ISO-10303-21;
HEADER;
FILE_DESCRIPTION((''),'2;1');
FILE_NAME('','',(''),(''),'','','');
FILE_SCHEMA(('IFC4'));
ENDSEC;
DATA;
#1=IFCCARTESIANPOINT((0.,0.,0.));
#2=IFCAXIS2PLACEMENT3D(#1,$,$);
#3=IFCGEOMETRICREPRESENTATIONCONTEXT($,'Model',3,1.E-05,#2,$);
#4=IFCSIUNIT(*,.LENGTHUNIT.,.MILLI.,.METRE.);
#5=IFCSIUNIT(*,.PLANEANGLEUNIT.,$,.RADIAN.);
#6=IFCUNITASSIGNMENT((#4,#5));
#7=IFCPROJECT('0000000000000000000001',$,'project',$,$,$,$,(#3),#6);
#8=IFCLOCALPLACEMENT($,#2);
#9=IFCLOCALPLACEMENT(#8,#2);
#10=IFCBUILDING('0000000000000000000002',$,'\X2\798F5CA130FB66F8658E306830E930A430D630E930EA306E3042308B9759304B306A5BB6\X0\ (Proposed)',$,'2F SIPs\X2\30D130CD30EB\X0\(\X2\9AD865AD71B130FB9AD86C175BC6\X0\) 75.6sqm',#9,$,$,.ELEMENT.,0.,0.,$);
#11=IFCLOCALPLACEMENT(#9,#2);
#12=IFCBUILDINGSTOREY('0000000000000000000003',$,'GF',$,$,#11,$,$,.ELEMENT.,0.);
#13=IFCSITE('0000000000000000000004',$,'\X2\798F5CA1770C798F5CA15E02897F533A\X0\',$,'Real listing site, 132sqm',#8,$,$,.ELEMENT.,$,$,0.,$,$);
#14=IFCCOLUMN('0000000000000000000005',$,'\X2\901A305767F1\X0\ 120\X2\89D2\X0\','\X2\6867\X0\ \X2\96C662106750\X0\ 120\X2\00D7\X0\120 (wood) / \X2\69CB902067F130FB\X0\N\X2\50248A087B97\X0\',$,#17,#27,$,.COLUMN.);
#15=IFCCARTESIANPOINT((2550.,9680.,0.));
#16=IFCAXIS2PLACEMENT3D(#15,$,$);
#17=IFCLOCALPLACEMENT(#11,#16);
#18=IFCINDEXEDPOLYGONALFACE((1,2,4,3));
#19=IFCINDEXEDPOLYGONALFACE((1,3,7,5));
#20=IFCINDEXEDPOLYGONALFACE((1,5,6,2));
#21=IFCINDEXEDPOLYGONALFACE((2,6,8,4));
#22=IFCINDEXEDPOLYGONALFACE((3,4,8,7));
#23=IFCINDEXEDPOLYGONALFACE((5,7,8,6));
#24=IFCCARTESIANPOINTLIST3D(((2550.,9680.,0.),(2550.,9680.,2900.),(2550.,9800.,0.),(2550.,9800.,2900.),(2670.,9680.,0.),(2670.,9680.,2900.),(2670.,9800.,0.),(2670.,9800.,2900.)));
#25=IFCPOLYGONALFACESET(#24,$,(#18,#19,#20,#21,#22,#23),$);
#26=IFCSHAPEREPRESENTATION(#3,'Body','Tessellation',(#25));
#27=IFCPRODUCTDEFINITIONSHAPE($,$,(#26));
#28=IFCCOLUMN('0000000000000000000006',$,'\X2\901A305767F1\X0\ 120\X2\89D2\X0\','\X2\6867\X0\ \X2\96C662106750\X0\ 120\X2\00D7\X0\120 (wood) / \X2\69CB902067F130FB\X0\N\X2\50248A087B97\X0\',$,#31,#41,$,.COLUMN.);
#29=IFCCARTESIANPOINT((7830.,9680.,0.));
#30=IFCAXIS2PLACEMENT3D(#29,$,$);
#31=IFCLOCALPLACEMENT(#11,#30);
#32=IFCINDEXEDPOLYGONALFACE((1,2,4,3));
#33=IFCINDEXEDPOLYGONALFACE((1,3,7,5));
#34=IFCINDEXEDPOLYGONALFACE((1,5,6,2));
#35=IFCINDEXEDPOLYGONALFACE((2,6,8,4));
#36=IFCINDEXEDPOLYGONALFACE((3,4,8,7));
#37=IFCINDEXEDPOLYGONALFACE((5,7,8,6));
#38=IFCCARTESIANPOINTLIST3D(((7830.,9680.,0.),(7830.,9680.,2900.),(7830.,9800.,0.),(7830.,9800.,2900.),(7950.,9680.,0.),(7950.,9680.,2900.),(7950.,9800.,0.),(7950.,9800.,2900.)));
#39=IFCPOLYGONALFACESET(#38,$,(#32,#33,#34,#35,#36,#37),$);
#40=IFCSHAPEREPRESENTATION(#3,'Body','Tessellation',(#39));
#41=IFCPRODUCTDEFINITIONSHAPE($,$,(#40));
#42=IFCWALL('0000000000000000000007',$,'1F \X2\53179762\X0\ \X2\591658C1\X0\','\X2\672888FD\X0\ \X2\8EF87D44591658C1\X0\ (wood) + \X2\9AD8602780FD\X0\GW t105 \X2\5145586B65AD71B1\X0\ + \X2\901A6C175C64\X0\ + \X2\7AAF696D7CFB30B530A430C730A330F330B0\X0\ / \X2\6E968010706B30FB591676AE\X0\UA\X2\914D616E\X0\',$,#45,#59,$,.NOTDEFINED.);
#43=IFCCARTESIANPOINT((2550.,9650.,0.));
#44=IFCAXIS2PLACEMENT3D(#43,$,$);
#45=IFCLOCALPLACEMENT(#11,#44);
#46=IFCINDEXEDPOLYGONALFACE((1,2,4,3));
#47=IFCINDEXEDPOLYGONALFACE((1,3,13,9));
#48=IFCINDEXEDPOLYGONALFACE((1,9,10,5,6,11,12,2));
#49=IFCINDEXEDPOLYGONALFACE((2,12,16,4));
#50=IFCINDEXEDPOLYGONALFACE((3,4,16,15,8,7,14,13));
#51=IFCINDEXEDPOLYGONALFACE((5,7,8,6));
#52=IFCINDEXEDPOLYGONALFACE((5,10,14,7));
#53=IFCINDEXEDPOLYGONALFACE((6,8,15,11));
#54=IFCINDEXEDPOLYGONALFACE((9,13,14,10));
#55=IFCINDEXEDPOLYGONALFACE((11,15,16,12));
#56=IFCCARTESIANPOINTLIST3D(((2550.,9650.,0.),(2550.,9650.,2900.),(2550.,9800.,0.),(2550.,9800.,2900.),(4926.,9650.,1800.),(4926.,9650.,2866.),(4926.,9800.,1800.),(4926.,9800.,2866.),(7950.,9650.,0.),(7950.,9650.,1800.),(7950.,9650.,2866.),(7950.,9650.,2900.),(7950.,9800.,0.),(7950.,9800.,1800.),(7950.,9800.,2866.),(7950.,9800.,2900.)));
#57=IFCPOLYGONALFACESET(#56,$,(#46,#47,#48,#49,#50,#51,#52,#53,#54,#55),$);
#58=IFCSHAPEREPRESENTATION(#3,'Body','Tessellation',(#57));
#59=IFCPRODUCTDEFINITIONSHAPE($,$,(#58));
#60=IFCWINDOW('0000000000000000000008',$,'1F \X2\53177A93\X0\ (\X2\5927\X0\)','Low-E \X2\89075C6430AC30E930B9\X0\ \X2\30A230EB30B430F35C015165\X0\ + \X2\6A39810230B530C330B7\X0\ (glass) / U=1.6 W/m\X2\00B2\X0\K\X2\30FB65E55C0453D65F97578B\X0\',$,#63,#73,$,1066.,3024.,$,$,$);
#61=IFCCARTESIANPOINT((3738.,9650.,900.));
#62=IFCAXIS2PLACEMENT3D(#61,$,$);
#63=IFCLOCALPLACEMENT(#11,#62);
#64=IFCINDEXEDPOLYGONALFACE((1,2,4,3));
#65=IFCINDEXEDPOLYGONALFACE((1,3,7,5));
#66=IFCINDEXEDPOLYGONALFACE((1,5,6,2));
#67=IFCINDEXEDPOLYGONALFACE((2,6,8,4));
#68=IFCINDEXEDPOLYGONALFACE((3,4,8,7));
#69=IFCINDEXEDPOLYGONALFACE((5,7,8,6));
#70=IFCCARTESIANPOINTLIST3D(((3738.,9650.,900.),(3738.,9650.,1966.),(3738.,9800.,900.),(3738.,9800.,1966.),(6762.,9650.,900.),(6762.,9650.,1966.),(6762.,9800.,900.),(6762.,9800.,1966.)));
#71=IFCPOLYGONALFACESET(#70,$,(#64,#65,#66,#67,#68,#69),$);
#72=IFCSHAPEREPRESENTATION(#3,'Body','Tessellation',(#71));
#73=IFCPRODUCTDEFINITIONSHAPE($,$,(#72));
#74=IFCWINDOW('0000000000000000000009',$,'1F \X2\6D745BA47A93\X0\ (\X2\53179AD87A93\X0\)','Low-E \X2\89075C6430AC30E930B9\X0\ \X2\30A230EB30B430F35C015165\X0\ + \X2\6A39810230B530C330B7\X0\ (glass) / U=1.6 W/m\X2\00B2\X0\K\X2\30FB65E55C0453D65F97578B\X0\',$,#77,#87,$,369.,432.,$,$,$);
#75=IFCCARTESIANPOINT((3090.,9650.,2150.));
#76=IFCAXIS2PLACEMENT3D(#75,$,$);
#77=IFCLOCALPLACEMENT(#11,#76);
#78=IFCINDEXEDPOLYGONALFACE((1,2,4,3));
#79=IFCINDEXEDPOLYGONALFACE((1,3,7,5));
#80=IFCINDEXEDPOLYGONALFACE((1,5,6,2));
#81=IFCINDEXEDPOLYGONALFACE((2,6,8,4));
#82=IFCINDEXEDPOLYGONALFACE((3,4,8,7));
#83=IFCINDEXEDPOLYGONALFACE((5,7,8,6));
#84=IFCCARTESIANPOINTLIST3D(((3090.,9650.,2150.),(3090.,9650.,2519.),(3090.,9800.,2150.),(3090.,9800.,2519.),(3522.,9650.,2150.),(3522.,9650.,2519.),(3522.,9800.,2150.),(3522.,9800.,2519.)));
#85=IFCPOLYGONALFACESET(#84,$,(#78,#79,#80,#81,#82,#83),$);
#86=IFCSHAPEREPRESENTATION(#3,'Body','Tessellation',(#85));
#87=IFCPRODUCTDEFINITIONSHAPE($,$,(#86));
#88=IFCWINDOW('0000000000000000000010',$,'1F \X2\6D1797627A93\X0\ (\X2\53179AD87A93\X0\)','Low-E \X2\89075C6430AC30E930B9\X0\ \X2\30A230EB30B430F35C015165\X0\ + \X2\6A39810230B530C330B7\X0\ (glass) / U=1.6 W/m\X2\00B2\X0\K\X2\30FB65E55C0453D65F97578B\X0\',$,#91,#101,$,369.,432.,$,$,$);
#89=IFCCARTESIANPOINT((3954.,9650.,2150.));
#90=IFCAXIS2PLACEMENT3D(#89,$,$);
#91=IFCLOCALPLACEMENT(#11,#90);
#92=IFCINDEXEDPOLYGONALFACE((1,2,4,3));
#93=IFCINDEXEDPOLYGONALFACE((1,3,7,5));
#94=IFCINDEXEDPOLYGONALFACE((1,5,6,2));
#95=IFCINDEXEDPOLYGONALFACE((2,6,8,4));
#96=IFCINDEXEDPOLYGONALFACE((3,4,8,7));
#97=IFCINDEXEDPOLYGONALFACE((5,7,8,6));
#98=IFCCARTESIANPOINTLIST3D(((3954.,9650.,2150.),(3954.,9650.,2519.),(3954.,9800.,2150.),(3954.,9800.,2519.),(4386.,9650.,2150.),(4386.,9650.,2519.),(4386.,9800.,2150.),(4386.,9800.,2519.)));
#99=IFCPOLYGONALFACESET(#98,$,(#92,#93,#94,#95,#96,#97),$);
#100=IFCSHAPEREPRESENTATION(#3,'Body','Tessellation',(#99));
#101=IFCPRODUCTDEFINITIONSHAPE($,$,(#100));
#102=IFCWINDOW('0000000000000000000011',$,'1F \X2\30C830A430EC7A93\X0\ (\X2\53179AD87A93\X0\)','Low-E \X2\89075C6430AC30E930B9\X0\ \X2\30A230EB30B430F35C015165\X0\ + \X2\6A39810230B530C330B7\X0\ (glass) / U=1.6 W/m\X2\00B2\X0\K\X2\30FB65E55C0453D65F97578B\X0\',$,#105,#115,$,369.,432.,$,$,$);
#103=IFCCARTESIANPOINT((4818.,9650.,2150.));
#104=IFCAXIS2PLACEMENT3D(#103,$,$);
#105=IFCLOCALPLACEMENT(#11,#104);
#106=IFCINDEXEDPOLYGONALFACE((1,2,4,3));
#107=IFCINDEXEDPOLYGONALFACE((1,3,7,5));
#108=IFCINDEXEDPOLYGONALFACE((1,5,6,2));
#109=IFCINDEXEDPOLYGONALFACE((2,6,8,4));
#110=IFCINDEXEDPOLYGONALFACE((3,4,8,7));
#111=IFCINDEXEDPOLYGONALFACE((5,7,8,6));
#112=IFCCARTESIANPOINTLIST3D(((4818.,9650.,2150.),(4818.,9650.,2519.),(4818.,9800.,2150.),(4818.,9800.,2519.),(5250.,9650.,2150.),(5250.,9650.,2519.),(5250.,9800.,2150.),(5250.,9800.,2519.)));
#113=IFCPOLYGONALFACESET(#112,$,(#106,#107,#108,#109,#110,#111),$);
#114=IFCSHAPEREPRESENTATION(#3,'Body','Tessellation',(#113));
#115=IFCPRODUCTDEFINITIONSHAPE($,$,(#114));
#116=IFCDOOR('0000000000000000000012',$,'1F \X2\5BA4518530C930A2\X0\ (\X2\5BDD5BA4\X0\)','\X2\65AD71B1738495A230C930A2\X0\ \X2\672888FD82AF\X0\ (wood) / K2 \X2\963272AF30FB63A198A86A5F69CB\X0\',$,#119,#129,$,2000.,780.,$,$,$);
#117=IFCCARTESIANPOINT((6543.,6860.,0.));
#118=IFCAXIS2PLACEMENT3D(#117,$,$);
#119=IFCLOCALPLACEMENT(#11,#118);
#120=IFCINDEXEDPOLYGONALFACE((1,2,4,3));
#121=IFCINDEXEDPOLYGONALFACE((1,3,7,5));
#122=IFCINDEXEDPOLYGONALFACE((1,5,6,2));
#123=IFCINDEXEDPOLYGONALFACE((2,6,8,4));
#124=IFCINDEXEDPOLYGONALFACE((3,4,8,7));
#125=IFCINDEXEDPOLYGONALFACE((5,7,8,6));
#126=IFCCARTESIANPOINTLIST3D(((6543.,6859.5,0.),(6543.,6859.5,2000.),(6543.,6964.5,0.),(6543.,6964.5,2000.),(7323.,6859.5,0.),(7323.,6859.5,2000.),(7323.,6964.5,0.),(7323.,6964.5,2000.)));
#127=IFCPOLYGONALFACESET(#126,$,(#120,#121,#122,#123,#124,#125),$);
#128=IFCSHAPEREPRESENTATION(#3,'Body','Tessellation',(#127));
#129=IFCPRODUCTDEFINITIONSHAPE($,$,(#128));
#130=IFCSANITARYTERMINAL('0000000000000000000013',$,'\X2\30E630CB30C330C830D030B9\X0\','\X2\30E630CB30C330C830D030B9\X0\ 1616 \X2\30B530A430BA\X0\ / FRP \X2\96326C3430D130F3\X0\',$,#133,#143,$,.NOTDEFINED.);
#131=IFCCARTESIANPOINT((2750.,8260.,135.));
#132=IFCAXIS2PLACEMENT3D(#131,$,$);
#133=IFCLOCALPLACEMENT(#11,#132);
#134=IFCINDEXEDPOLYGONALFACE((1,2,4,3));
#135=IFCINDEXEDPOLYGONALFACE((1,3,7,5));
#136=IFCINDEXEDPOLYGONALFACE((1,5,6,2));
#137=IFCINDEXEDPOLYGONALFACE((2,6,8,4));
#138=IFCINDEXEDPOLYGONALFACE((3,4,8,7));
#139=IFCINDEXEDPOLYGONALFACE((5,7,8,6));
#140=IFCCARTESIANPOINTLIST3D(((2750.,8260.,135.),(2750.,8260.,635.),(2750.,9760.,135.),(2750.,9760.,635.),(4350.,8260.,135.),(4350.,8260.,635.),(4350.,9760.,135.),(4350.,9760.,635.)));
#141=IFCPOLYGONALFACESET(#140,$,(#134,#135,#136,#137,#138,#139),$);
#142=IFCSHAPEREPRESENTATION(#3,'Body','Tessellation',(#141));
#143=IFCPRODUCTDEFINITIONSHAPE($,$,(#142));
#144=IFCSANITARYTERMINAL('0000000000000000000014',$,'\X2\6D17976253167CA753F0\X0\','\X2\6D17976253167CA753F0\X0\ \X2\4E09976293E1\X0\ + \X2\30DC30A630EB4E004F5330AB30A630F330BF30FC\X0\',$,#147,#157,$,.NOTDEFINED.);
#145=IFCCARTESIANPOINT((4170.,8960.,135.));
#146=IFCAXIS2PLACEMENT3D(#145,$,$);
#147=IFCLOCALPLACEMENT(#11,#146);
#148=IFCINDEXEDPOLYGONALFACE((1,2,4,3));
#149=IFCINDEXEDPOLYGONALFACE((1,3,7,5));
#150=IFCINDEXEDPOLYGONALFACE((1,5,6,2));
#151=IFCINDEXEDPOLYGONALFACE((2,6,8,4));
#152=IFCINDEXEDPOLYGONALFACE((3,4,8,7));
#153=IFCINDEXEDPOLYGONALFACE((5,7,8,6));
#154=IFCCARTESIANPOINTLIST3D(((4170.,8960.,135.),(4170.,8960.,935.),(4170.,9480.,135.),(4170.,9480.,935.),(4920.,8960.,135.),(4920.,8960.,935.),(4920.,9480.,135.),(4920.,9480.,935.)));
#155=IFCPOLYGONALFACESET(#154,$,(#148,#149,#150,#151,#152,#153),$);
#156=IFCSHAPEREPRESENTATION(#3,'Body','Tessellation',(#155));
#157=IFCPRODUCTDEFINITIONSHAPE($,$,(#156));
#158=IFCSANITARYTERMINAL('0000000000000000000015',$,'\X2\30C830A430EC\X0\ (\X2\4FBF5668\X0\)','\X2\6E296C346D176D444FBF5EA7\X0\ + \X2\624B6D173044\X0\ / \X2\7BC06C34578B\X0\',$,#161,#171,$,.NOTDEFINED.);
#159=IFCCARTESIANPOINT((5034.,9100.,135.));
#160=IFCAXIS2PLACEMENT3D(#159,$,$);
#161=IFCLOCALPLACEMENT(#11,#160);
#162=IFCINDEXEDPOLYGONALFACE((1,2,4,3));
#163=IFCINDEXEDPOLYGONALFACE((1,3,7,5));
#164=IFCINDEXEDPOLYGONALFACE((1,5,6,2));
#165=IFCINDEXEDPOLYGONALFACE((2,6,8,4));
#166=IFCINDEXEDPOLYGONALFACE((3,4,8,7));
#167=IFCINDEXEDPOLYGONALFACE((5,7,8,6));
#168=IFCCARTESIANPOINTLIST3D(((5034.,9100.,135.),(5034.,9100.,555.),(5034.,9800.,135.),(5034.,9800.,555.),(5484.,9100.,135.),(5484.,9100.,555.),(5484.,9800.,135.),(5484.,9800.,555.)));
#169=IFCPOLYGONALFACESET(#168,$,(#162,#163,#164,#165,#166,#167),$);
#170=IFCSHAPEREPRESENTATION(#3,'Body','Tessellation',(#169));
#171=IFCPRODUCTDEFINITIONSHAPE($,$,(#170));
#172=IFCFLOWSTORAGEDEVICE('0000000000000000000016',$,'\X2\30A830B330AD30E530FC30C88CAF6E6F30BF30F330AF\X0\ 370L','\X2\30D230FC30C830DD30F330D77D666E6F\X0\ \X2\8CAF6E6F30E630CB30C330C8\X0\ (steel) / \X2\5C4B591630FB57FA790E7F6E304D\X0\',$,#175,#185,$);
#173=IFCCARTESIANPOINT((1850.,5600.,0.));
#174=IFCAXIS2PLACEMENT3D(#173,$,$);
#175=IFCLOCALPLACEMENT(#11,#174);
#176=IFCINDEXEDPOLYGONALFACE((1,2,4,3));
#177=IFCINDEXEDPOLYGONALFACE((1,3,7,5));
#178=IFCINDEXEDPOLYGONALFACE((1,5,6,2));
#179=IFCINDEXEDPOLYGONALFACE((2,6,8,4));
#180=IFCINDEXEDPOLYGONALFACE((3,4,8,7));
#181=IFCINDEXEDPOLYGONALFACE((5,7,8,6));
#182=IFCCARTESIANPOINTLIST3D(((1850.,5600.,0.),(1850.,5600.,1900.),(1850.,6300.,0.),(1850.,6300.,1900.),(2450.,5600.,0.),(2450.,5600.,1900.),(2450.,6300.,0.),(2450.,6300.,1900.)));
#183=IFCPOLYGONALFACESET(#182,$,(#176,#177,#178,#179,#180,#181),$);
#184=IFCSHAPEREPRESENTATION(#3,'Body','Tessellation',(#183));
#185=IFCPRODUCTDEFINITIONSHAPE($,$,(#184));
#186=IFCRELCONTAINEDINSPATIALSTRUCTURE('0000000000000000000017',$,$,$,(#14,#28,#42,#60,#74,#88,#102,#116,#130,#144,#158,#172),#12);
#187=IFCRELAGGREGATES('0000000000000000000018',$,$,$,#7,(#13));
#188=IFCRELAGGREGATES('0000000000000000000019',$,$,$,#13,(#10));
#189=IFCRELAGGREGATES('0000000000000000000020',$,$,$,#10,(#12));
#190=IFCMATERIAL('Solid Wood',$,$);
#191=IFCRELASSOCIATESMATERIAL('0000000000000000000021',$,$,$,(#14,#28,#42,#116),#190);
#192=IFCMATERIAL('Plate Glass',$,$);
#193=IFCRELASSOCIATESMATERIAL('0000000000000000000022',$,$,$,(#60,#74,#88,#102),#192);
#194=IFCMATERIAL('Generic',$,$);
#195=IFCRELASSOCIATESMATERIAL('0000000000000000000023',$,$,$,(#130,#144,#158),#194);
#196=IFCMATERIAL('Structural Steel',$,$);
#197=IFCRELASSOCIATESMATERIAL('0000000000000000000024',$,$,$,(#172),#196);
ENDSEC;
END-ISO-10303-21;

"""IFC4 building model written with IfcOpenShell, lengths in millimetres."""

from ifc_helpers import new_model, si_unit, frame, frame_2d, origin, place, context, project, spatial, rectangle, extrude, material, element, fill, save


model = new_model("IFC4")

# Units and contexts
model_context = context("Model", 3, precision=1e-05, world=origin())
ifc_project = project(units=[si_unit("LENGTHUNIT", "METRE", prefix="MILLI"), si_unit("PLANEANGLEUNIT", "RADIAN")], contexts=[model_context])

# Site, building, storey
site_placement = place(None, origin())
site = spatial("IfcSite", under=ifc_project, at=site_placement, Name="福岡県福岡市西区", ObjectType="Real listing site, 132sqm", CompositionType="ELEMENT", RefElevation=0.0)
building_placement = place(site_placement, origin())
building = spatial("IfcBuilding", under=site, at=building_placement, Name="福岡・書斎とライブラリのある静かな家 (Proposed)", ObjectType="2F SIPsパネル(高断熱・高気密) 75.6sqm", CompositionType="ELEMENT", ElevationOfRefHeight=0.0, ElevationOfTerrain=0.0)
storey_placement = place(building_placement, origin())
storey = spatial("IfcBuildingStorey", under=building, at=storey_placement, Name="GF", CompositionType="ELEMENT", Elevation=0.0)

# Columns
ifc_material_1 = material(Name="Solid Wood")
column_1_placement = place(storey_placement, frame((2550.0, 9680.0, 0.0)))
element("IfcColumn", 1, at=column_1_placement, inside=storey, material=ifc_material_1, Name="通し柱 120角", Description="桧 集成材 120×120 (wood) / 構造柱・N値計算", PredefinedType="COLUMN", context=model_context, shape_type="SweptSolid", body=[
    extrude(rectangle(XDim=120.0, YDim=120.0, at=frame_2d((60.0, 60.0))), frame((2550.0, 9680.0, 0.0)), (0.0, 0.0, 1.0), 2900.0),
])
column_2_placement = place(storey_placement, frame((7830.0, 9680.0, 0.0)))
element("IfcColumn", 2, at=column_2_placement, inside=storey, material=ifc_material_1, Name="通し柱 120角", Description="桧 集成材 120×120 (wood) / 構造柱・N値計算", PredefinedType="COLUMN", context=model_context, shape_type="SweptSolid", body=[
    extrude(rectangle(XDim=120.0, YDim=120.0, at=frame_2d((60.0, 60.0))), frame((7830.0, 9680.0, 0.0)), (0.0, 0.0, 1.0), 2900.0),
])

# Wall, openings, windows
wall_1_placement = place(storey_placement, frame((2550.0, 9650.0, 0.0)))
wall_1 = element("IfcWall", 3, at=wall_1_placement, inside=storey, material=ifc_material_1, Name="1F 北面 外壁", Description="木製 軸組外壁 (wood) + 高性能GW t105 充填断熱 + 通気層 + 窯業系サイディング / 準耐火・外皮UA配慮", PredefinedType="NOTDEFINED", context=model_context, shape_type="SweptSolid", body=[
    extrude(rectangle(XDim=5400.0, YDim=150.0, at=frame_2d((2700.0, 75.0))), frame((2550.0, 9650.0, 0.0)), (0.0, 0.0, 1.0), 2900.0),
])
opening_1_placement = place(storey_placement, frame((3738.0, 9650.0, 900.0)))
opening_1 = element("IfcOpeningElement", 4, at=opening_1_placement, cuts=wall_1, PredefinedType="NOTDEFINED", context=model_context, shape_type="SweptSolid", body=[
    extrude(rectangle(XDim=3024.0, YDim=150.0, at=frame_2d((1512.0, 75.0))), frame((3738.0, 9650.0, 900.0)), (0.0, 0.0, 1.0), 1066.0),
])
opening_2_placement = place(storey_placement, frame((3090.0, 9650.0, 2150.0)))
opening_2 = element("IfcOpeningElement", 5, at=opening_2_placement, cuts=wall_1, PredefinedType="NOTDEFINED", context=model_context, shape_type="SweptSolid", body=[
    extrude(rectangle(XDim=432.0, YDim=150.0, at=frame_2d((216.0, 75.0))), frame((3090.0, 9650.0, 2150.0)), (0.0, 0.0, 1.0), 369.0),
])
opening_3_placement = place(storey_placement, frame((3954.0, 9650.0, 2150.0)))
opening_3 = element("IfcOpeningElement", 6, at=opening_3_placement, cuts=wall_1, PredefinedType="NOTDEFINED", context=model_context, shape_type="SweptSolid", body=[
    extrude(rectangle(XDim=432.0, YDim=150.0, at=frame_2d((216.0, 75.0))), frame((3954.0, 9650.0, 2150.0)), (0.0, 0.0, 1.0), 369.0),
])
opening_4_placement = place(storey_placement, frame((4818.0, 9650.0, 2150.0)))
opening_4 = element("IfcOpeningElement", 7, at=opening_4_placement, cuts=wall_1, PredefinedType="NOTDEFINED", context=model_context, shape_type="SweptSolid", body=[
    extrude(rectangle(XDim=432.0, YDim=150.0, at=frame_2d((216.0, 75.0))), frame((4818.0, 9650.0, 2150.0)), (0.0, 0.0, 1.0), 369.0),
])
ifc_material_2 = material(Name="Plate Glass")
window_1_placement = place(storey_placement, frame((3738.0, 9650.0, 900.0)))
window_1 = element("IfcWindow", 8, at=window_1_placement, inside=storey, material=ifc_material_2, Name="1F 北窓 (大)", Description="Low-E 複層ガラス アルゴン封入 + 樹脂サッシ (glass) / U=1.6 W/m²K・日射取得型", OverallHeight=1066.0, OverallWidth=3024.0, context=model_context, shape_type="SweptSolid", body=[
    extrude(rectangle(XDim=3024.0, YDim=150.0, at=frame_2d((1512.0, 75.0))), frame((3738.0, 9650.0, 900.0)), (0.0, 0.0, 1.0), 1066.0),
])
fill(opening_1, window_1)
window_2_placement = place(storey_placement, frame((3090.0, 9650.0, 2150.0)))
window_2 = element("IfcWindow", 9, at=window_2_placement, inside=storey, material=ifc_material_2, Name="1F 浴室窓 (北高窓)", Description="Low-E 複層ガラス アルゴン封入 + 樹脂サッシ (glass) / U=1.6 W/m²K・日射取得型", OverallHeight=369.0, OverallWidth=432.0, context=model_context, shape_type="SweptSolid", body=[
    extrude(rectangle(XDim=432.0, YDim=150.0, at=frame_2d((216.0, 75.0))), frame((3090.0, 9650.0, 2150.0)), (0.0, 0.0, 1.0), 369.0),
])
fill(opening_2, window_2)
window_3_placement = place(storey_placement, frame((3954.0, 9650.0, 2150.0)))
window_3 = element("IfcWindow", 10, at=window_3_placement, inside=storey, material=ifc_material_2, Name="1F 洗面窓 (北高窓)", Description="Low-E 複層ガラス アルゴン封入 + 樹脂サッシ (glass) / U=1.6 W/m²K・日射取得型", OverallHeight=369.0, OverallWidth=432.0, context=model_context, shape_type="SweptSolid", body=[
    extrude(rectangle(XDim=432.0, YDim=150.0, at=frame_2d((216.0, 75.0))), frame((3954.0, 9650.0, 2150.0)), (0.0, 0.0, 1.0), 369.0),
])
fill(opening_3, window_3)
window_4_placement = place(storey_placement, frame((4818.0, 9650.0, 2150.0)))
window_4 = element("IfcWindow", 11, at=window_4_placement, inside=storey, material=ifc_material_2, Name="1F トイレ窓 (北高窓)", Description="Low-E 複層ガラス アルゴン封入 + 樹脂サッシ (glass) / U=1.6 W/m²K・日射取得型", OverallHeight=369.0, OverallWidth=432.0, context=model_context, shape_type="SweptSolid", body=[
    extrude(rectangle(XDim=432.0, YDim=150.0, at=frame_2d((216.0, 75.0))), frame((4818.0, 9650.0, 2150.0)), (0.0, 0.0, 1.0), 369.0),
])
fill(opening_4, window_4)

# Door
door_1_placement = place(storey_placement, frame((6543.0, 6860.0, 0.0)))
element("IfcDoor", 12, at=door_1_placement, inside=storey, material=ifc_material_1, Name="1F 室内ドア (寝室)", Description="断熱玄関ドア 木製芯 (wood) / K2 防犯・採風機構", OverallHeight=2000.0, OverallWidth=780.0, context=model_context, shape_type="SweptSolid", body=[
    extrude(rectangle(XDim=780.0, YDim=105.0, at=frame_2d((390.0, 52.0))), frame((6543.0, 6860.0, 0.0)), (0.0, 0.0, 1.0), 2000.0),
])

# Sanitary terminals
ifc_material_3 = material(Name="Generic")
sanitary_terminal_1_placement = place(storey_placement, frame((2750.0, 8260.0, 135.0)))
element("IfcSanitaryTerminal", 13, at=sanitary_terminal_1_placement, inside=storey, material=ifc_material_3, Name="ユニットバス", Description="ユニットバス 1616 サイズ / FRP 防水パン", PredefinedType="NOTDEFINED", context=model_context, shape_type="SweptSolid", body=[
    extrude(rectangle(XDim=1600.0, YDim=1500.0, at=frame_2d((800.0, 750.0))), frame((2750.0, 8260.0, 135.0)), (0.0, 0.0, 1.0), 500.0),
])
sanitary_terminal_2_placement = place(storey_placement, frame((4170.0, 8960.0, 135.0)))
element("IfcSanitaryTerminal", 14, at=sanitary_terminal_2_placement, inside=storey, material=ifc_material_3, Name="洗面化粧台", Description="洗面化粧台 三面鏡 + ボウル一体カウンター", PredefinedType="NOTDEFINED", context=model_context, shape_type="SweptSolid", body=[
    extrude(rectangle(XDim=750.0, YDim=520.0, at=frame_2d((375.0, 260.0))), frame((4170.0, 8960.0, 135.0)), (0.0, 0.0, 1.0), 800.0),
])
sanitary_terminal_3_placement = place(storey_placement, frame((5034.0, 9100.0, 135.0)))
element("IfcSanitaryTerminal", 15, at=sanitary_terminal_3_placement, inside=storey, material=ifc_material_3, Name="トイレ (便器)", Description="温水洗浄便座 + 手洗い / 節水型", PredefinedType="NOTDEFINED", context=model_context, shape_type="SweptSolid", body=[
    extrude(rectangle(XDim=450.0, YDim=700.0, at=frame_2d((225.0, 350.0))), frame((5034.0, 9100.0, 135.0)), (0.0, 0.0, 1.0), 420.0),
])

# Flow storage device
ifc_material_4 = material(Name="Structural Steel")
flow_storage_device_placement = place(storey_placement, frame((1850.0, 5600.0, 0.0)))
element("IfcFlowStorageDevice", 16, at=flow_storage_device_placement, inside=storey, material=ifc_material_4, Name="エコキュート貯湯タンク 370L", Description="ヒートポンプ給湯 貯湯ユニット (steel) / 屋外・基礎置き", context=model_context, shape_type="SweptSolid", body=[
    extrude(rectangle(XDim=600.0, YDim=700.0, at=frame_2d((300.0, 350.0))), frame((1850.0, 5600.0, 0.0)), (0.0, 0.0, 1.0), 1900.0),
])

save(model, "model.ifc")
